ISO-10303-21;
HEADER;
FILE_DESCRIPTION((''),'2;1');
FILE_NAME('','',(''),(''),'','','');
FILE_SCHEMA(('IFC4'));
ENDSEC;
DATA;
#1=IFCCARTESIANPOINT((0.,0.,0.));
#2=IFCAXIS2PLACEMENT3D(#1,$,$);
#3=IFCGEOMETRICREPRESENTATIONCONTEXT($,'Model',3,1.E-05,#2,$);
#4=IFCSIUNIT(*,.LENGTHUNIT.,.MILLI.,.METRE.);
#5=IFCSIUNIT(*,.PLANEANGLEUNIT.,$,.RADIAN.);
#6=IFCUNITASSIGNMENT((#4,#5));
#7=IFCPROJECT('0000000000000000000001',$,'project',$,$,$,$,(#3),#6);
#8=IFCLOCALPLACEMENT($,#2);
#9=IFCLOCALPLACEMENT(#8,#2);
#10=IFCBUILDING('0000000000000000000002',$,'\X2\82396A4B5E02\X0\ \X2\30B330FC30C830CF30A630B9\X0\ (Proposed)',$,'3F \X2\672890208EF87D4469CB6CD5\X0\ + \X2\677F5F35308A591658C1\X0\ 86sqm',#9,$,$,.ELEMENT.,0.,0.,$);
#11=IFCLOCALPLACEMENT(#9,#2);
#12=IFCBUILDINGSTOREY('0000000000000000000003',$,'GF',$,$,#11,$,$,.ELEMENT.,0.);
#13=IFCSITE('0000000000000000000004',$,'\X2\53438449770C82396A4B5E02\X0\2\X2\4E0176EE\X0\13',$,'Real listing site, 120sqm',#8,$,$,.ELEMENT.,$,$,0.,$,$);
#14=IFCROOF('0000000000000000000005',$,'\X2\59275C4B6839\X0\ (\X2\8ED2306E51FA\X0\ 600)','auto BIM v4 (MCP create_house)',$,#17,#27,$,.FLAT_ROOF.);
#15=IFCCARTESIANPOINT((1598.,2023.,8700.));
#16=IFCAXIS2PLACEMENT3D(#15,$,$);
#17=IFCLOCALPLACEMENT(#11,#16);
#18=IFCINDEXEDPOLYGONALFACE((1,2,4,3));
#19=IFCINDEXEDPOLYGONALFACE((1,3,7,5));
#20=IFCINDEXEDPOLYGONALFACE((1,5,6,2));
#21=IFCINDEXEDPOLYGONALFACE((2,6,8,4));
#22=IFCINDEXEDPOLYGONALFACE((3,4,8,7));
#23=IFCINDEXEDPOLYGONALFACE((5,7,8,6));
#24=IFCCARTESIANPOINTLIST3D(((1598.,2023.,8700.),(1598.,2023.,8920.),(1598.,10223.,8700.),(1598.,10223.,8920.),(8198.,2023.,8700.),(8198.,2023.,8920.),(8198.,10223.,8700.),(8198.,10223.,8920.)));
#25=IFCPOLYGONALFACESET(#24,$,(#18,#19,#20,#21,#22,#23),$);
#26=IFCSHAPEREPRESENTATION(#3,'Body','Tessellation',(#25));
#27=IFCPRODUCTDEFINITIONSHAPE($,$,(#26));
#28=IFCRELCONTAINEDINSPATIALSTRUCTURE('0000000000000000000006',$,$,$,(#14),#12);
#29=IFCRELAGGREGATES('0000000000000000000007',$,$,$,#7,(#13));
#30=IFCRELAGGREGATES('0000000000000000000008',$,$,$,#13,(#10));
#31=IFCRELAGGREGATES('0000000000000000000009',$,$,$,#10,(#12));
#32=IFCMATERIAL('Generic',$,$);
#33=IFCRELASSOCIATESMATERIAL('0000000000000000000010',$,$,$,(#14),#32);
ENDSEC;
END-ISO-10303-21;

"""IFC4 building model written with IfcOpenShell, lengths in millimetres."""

from ifc_helpers import new_model, si_unit, frame, frame_2d, origin, place, context, project, spatial, rectangle, extrude, material, element, save


model = new_model("IFC4")

# Units and contexts
model_context = context("Model", 3, precision=1e-05, world=origin())
ifc_project = project(units=[si_unit("LENGTHUNIT", "METRE", prefix="MILLI"), si_unit("PLANEANGLEUNIT", "RADIAN")], contexts=[model_context])

# Site, building, storey
site_placement = place(None, origin())
site = spatial("IfcSite", under=ifc_project, at=site_placement, Name="千葉県船橋市2丁目13", ObjectType="Real listing site, 120sqm", CompositionType="ELEMENT", RefElevation=0.0)
building_placement = place(site_placement, origin())
building = spatial("IfcBuilding", under=site, at=building_placement, Name="船橋市 コートハウス (Proposed)", ObjectType="3F 木造軸組構法 + 板張り外壁 86sqm", CompositionType="ELEMENT", ElevationOfRefHeight=0.0, ElevationOfTerrain=0.0)
storey_placement = place(building_placement, origin())
storey = spatial("IfcBuildingStorey", under=building, at=storey_placement, Name="GF", CompositionType="ELEMENT", Elevation=0.0)

# Shared definitions
ifc_material = material(Name="Generic")

# Roof
roof_placement = place(storey_placement, frame((1598.0, 2023.0, 8700.0)))
element("IfcRoof", 1, at=roof_placement, inside=storey, material=ifc_material, Name="大屋根 (軒の出 600)", Description="auto BIM v4 (MCP create_house)", PredefinedType="FLAT_ROOF", context=model_context, shape_type="SweptSolid", body=[
    extrude(rectangle(XDim=6600.0, YDim=8200.0, at=frame_2d((3300.0, 4100.0))), frame((1598.0, 2023.0, 8700.0)), (0.0, 0.0, 1.0), 220.0),
])

save(model, "model.ifc")
